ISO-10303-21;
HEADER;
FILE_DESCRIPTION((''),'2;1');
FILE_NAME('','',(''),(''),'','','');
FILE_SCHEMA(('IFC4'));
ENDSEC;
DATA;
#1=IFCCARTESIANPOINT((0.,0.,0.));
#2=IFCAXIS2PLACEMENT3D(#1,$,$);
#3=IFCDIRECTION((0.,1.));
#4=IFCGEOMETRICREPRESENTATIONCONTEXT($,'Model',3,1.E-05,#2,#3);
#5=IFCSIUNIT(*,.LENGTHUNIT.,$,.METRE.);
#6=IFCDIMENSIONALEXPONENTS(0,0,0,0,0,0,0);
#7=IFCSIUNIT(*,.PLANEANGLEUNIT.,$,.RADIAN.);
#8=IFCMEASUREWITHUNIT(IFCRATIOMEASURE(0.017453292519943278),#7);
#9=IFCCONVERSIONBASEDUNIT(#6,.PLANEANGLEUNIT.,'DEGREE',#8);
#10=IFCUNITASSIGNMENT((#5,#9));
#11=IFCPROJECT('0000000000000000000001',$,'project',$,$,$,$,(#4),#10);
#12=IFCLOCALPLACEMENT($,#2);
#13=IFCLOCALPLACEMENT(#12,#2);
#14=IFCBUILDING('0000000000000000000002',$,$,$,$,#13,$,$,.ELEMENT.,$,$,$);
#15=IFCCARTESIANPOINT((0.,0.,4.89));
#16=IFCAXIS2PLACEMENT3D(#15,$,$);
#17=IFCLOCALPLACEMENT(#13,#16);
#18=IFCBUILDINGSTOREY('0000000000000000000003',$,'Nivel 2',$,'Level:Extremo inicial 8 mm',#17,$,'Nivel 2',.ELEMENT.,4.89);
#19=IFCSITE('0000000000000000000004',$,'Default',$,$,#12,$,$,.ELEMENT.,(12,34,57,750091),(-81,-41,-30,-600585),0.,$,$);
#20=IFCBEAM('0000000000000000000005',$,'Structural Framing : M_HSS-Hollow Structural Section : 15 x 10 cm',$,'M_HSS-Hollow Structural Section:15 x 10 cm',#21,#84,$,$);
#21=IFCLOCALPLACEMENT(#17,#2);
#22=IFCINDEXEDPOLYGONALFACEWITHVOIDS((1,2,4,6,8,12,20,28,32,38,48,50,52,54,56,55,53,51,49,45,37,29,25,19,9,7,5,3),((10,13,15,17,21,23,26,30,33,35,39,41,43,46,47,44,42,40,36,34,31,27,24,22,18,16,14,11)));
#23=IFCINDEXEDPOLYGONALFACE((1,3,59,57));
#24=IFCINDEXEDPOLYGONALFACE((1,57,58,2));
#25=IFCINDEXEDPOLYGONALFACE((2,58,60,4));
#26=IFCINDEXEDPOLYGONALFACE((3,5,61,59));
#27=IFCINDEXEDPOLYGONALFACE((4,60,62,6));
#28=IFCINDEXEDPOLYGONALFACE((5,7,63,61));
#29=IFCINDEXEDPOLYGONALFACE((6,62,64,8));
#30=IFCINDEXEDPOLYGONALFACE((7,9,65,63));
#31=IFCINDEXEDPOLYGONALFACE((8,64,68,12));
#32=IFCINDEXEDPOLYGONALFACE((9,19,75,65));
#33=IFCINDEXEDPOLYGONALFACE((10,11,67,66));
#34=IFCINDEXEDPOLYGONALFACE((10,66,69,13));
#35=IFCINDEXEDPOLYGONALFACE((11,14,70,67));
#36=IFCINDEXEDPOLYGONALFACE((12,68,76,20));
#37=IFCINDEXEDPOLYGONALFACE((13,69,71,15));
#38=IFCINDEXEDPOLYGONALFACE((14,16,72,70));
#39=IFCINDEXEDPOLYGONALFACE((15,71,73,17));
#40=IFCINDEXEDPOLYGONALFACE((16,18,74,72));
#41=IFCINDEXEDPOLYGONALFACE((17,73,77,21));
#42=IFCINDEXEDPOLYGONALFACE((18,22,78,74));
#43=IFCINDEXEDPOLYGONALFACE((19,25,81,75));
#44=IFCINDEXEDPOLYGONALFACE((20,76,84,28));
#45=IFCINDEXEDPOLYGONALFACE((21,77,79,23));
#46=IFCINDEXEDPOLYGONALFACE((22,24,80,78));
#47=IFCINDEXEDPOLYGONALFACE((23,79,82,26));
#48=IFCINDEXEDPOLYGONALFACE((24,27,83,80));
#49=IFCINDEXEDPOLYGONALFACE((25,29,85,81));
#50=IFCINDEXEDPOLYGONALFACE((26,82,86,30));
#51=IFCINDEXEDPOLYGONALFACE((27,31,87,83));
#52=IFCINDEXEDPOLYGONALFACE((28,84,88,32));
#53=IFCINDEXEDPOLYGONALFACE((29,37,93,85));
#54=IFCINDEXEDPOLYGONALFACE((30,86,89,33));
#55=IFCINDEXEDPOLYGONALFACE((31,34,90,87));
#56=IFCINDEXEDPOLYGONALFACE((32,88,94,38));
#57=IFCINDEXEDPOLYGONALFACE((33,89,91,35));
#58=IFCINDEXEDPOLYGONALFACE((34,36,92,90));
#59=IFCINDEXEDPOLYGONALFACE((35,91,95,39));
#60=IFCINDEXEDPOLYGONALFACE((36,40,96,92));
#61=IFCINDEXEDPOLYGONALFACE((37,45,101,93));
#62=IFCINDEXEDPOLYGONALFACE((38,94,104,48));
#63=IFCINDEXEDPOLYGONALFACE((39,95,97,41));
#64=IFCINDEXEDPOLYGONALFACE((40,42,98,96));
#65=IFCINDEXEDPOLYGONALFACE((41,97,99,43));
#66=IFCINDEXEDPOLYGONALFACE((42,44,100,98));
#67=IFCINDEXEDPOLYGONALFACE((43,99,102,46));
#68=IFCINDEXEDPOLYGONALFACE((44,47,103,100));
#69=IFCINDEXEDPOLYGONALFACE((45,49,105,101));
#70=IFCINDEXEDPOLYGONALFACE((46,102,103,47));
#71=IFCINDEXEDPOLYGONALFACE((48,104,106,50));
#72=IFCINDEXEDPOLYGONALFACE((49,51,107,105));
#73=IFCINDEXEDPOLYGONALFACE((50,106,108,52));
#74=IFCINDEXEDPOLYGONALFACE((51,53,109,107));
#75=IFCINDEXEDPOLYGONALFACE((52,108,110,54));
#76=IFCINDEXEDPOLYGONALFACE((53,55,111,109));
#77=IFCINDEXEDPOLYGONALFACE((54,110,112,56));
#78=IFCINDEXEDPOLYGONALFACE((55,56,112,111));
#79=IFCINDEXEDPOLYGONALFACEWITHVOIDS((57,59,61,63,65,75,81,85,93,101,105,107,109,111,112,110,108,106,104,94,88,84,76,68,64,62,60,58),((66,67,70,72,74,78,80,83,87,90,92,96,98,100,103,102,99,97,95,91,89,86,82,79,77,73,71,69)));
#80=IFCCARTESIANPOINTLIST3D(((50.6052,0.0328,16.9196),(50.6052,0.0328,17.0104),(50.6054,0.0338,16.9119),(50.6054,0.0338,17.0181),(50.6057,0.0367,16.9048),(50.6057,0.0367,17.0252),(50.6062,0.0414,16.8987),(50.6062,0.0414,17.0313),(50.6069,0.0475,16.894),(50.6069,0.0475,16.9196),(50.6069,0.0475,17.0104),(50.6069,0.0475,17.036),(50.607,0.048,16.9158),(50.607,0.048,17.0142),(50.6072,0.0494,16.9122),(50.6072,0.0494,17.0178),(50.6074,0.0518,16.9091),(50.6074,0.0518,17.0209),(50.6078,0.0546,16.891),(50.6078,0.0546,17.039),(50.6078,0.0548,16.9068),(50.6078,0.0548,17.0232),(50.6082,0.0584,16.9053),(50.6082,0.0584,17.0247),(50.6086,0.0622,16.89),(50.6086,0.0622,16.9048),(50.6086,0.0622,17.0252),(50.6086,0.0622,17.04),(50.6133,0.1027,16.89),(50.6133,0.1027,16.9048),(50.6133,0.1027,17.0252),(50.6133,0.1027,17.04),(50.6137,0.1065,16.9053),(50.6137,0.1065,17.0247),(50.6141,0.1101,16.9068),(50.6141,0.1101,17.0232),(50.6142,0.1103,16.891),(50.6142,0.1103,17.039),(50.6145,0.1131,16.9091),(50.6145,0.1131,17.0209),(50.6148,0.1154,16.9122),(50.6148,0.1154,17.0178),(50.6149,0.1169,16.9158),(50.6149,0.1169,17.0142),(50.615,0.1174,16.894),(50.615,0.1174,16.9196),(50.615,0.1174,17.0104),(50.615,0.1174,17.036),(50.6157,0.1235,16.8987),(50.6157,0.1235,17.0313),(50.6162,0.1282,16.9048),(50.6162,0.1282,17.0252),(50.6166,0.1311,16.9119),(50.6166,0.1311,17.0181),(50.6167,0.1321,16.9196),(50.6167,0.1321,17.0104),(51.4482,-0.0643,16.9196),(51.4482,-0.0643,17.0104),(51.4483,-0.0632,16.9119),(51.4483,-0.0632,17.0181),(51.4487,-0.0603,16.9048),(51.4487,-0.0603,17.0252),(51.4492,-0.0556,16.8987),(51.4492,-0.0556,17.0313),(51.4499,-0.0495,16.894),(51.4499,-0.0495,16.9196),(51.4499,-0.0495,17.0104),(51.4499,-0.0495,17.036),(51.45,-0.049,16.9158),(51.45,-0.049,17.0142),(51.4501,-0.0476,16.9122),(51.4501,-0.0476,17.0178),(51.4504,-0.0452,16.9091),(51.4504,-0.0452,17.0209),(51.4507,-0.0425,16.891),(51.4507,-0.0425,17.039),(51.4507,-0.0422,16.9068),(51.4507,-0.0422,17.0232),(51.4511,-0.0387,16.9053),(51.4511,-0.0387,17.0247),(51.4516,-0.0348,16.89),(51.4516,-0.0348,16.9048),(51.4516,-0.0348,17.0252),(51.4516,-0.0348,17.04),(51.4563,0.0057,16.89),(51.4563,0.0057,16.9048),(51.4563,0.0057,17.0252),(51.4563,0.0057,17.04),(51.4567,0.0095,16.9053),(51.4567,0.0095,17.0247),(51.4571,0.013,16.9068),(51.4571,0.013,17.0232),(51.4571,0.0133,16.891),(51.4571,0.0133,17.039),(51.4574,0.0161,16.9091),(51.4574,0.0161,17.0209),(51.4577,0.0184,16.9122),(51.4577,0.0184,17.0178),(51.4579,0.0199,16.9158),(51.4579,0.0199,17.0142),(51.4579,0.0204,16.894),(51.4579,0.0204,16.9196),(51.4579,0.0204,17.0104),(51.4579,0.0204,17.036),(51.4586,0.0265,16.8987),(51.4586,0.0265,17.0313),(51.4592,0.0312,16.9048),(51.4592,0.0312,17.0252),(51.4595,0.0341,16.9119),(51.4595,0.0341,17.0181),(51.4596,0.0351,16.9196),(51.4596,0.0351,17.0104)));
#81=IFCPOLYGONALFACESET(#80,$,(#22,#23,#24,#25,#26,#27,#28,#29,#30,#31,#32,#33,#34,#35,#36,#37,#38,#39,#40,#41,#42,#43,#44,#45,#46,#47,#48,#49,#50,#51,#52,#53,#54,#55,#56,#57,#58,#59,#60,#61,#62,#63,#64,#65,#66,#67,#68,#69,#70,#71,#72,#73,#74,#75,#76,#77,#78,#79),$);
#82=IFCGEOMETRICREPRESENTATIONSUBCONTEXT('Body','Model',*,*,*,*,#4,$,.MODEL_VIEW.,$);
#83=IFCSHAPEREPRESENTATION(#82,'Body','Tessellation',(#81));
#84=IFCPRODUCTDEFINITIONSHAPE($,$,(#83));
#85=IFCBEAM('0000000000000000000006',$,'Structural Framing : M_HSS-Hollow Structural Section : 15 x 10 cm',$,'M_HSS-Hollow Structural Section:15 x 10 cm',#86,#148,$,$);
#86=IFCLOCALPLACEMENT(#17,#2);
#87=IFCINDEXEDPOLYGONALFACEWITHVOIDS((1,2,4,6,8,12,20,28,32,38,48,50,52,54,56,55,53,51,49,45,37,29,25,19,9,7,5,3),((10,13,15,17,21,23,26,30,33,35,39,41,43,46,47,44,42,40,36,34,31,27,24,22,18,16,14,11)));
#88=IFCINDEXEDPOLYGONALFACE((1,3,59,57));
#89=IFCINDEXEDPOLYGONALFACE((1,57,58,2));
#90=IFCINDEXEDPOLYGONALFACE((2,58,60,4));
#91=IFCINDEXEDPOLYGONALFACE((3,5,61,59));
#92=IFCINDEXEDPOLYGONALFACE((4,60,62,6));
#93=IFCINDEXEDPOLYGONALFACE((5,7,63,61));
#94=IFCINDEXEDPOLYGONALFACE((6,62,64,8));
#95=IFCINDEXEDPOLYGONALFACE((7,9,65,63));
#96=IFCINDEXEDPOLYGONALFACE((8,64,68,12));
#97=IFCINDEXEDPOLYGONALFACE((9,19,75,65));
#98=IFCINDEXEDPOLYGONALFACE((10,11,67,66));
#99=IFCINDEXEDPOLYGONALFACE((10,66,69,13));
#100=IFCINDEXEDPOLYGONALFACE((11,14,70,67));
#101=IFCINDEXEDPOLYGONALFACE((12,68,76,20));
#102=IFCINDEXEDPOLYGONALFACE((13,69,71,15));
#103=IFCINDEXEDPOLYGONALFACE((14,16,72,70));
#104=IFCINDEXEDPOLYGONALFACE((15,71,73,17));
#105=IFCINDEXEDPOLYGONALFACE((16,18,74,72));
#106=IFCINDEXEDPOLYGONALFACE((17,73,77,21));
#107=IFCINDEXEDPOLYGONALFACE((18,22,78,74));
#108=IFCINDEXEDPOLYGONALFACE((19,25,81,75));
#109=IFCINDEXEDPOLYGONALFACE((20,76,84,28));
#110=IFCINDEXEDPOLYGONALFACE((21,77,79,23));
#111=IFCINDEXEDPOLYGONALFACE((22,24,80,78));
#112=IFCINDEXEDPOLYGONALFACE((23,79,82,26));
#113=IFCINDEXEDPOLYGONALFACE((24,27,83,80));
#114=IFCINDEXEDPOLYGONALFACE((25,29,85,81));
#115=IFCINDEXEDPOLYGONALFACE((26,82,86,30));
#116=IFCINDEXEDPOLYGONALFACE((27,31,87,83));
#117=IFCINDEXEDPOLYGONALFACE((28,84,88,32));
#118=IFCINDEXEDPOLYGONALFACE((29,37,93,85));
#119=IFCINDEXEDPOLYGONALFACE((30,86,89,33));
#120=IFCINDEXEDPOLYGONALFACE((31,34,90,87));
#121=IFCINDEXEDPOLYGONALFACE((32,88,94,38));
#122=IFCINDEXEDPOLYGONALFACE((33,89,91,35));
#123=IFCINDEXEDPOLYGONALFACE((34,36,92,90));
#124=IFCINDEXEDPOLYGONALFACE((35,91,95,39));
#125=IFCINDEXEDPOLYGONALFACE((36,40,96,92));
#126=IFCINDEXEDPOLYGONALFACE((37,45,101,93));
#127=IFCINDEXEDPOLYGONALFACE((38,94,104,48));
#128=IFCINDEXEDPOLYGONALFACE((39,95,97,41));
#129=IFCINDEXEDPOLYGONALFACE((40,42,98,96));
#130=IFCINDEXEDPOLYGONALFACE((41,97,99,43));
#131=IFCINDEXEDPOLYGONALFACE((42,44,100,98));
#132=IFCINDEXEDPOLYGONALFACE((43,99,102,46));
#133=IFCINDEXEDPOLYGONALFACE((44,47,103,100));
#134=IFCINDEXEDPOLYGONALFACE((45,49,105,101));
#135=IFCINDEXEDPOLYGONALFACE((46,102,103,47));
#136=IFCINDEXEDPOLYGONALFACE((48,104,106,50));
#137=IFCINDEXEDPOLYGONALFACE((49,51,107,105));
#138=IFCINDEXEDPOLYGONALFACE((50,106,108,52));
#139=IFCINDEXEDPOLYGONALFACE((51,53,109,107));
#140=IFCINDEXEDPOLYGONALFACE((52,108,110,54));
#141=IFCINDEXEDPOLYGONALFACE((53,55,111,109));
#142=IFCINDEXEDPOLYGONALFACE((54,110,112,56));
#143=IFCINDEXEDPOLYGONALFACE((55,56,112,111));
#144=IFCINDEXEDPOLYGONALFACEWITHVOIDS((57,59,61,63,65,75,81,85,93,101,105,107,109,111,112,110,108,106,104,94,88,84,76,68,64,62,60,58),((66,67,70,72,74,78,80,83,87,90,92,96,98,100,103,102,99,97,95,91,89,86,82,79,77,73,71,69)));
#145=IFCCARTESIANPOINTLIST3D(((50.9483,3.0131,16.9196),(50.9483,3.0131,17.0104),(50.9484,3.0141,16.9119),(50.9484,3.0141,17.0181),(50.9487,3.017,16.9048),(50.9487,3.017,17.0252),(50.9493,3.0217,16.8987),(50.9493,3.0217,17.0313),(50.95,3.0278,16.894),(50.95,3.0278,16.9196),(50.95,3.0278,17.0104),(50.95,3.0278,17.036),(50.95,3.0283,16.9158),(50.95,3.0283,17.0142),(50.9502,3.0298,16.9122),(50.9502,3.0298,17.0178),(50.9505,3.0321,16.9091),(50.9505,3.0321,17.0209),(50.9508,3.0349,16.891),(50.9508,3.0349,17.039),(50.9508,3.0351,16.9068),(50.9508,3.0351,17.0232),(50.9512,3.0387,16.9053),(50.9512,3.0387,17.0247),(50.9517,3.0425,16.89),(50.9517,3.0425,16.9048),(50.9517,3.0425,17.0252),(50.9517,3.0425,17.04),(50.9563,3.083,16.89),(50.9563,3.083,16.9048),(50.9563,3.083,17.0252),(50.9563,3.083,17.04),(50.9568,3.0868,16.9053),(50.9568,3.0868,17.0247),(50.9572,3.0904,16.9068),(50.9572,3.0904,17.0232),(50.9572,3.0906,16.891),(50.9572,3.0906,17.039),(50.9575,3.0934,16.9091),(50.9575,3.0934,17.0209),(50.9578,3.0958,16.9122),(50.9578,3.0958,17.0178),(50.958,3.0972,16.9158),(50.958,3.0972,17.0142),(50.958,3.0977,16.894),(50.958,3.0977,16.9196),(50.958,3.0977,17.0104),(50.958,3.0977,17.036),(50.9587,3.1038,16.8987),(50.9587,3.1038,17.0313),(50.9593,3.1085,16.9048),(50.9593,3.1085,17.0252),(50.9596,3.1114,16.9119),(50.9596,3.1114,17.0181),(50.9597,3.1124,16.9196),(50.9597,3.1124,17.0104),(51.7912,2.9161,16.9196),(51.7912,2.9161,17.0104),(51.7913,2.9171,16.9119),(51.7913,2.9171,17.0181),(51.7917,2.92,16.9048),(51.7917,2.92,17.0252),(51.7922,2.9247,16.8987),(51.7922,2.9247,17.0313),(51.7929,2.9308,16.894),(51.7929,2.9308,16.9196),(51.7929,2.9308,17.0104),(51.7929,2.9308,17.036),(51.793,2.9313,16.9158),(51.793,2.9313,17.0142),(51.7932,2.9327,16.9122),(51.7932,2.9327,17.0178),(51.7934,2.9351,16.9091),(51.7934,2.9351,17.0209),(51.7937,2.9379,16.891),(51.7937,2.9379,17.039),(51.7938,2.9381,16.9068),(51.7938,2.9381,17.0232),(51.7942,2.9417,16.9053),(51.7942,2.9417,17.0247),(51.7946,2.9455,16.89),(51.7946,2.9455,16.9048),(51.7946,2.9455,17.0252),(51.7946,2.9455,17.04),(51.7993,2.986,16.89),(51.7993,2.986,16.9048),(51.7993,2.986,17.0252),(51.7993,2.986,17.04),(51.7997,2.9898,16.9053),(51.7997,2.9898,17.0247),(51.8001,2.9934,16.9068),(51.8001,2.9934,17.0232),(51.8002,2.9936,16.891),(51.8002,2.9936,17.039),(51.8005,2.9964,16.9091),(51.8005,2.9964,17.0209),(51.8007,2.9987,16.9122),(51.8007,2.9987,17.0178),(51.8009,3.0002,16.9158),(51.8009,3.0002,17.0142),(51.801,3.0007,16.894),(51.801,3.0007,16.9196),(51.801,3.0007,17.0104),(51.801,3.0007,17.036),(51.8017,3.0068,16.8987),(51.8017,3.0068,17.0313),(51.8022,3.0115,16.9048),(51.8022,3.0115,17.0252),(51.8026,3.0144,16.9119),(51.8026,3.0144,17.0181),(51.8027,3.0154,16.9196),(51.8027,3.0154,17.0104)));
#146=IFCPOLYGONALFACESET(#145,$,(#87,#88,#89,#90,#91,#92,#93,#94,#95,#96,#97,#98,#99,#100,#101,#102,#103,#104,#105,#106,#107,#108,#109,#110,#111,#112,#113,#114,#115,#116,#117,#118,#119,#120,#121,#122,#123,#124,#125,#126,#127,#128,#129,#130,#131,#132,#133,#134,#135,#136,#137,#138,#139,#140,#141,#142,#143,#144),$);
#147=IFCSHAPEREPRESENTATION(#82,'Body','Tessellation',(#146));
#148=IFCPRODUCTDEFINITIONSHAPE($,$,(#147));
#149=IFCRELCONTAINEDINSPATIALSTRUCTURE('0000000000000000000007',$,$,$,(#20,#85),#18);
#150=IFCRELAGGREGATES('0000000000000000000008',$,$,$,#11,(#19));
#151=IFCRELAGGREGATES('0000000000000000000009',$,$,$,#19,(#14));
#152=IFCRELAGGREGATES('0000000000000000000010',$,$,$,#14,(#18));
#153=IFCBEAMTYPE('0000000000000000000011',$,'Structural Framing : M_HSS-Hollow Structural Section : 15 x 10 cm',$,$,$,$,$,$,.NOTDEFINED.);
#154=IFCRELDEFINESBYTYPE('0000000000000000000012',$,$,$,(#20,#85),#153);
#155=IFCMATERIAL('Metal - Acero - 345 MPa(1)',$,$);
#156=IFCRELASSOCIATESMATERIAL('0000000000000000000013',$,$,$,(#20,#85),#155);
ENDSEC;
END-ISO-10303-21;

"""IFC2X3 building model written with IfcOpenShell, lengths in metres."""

from ifc_helpers import new_model, entity, si_unit, converted_unit, direction, frame, frame_2d, origin, place, context, subcontext, project, spatial, polyline, circle_curve, parameter, trimmed, segment, composite_curve, outline, extrude, material, type_object, element, save


model = new_model("IFC2X3")

# Units and contexts
model_context = context("Model", 3, precision=1e-05, world=origin(), true_north=direction((0.0, 1.0)))
body_context = subcontext(model_context, "Body", "Model", "MODEL_VIEW")
ifc_project = project(units=[si_unit("LENGTHUNIT", "METRE"), converted_unit("PLANEANGLEUNIT", "DEGREE", entity("IfcRatioMeasure", 0.017453292519943278), si_unit("PLANEANGLEUNIT", "RADIAN"), dimensions=[0, 0, 0, 0, 0, 0, 0])], contexts=[model_context])

# Site, building, storey
site_placement = place(None, origin())
site = spatial("IfcSite", under=ifc_project, at=site_placement, Name="Default", CompositionType="ELEMENT", RefLatitude=(12, 34, 57, 750091), RefLongitude=(-81, -41, -30, -600585), RefElevation=0.0)
building_placement = place(site_placement, origin())
building = spatial("IfcBuilding", under=site, at=building_placement, CompositionType="ELEMENT")
storey_placement = place(building_placement, frame((0.0, 0.0, 4.89)))
storey = spatial("IfcBuildingStorey", under=building, at=storey_placement, Name="Nivel 2", ObjectType="Level:Extremo inicial 8 mm", LongName="Nivel 2", CompositionType="ELEMENT", Elevation=4.89)

# Shared definitions
ifc_material_1 = material(Name="Metal - Acero - 345 MPa(1)")

# Beams
beam_type_1 = type_object("IfcBeamType", Name="Structural Framing : M_HSS-Hollow Structural Section : 15 x 10 cm", PredefinedType="NOTDEFINED")
beam_1_placement = place(storey_placement, frame((51.8016, -0.0546, 17.04), z_axis=(0.0, 0.0, 1.0), x_axis=(-0.993441, 0.114344, 0.0)))
element("IfcBeam", 1, at=beam_1_placement, inside=storey, type_object=beam_type_1, material=ifc_material_1, Name="Structural Framing : M_HSS-Hollow Structural Section : 15 x 10 cm", ObjectType="M_HSS-Hollow Structural Section:15 x 10 cm", context=body_context, shape_type="SweptSolid", body=[
    extrude(outline(composite_curve([segment(trimmed(circle_curve(frame_2d((-0.0204, -0.0454), x_axis=(1.0, 0.0)), 0.0296), [parameter(180.0)], [parameter(270.0)], True, "PARAMETER"), True, "CONTINUOUS"), segment(polyline([(-0.0204, -0.075), (0.0204, -0.075)]), True, "CONTINUOUS"), segment(trimmed(circle_curve(frame_2d((0.0204, -0.0454), x_axis=(1.0, 0.0)), 0.0296), [parameter(270.0)], [parameter(0.0)], True, "PARAMETER"), True, "CONTINUOUS"), segment(polyline([(0.05, -0.0454), (0.05, 0.0454)]), True, "CONTINUOUS"), segment(trimmed(circle_curve(frame_2d((0.0204, 0.0454), x_axis=(1.0, 0.0)), 0.0296), [parameter(360.0)], [parameter(90.0)], True, "PARAMETER"), True, "CONTINUOUS"), segment(polyline([(0.0204, 0.075), (-0.0204, 0.075)]), True, "CONTINUOUS"), segment(trimmed(circle_curve(frame_2d((-0.0204, 0.0454), x_axis=(1.0, 0.0)), 0.0296), [parameter(90.0)], [parameter(180.0)], True, "PARAMETER"), True, "CONTINUOUS"), segment(polyline([(-0.05, 0.0454), (-0.05, -0.0454)]), True, "CONTINUOUS")], self_intersect=False), holes=[composite_curve([segment(polyline([(0.0204, -0.0602), (-0.0204, -0.0602)]), True, "CONTINUOUS"), segment(trimmed(circle_curve(frame_2d((-0.0204, -0.0454), x_axis=(1.0, 0.0)), 0.0148), [parameter(180.0)], [parameter(270.0)], True, "PARAMETER"), False, "CONTINUOUS"), segment(polyline([(-0.0352, -0.0454), (-0.0352, 0.0454)]), True, "CONTINUOUS"), segment(trimmed(circle_curve(frame_2d((-0.0204, 0.0454), x_axis=(1.0, 0.0)), 0.0148), [parameter(90.0)], [parameter(180.0)], True, "PARAMETER"), False, "CONTINUOUS"), segment(polyline([(-0.0204, 0.0602), (0.0204, 0.0602)]), True, "CONTINUOUS"), segment(trimmed(circle_curve(frame_2d((0.0204, 0.0454), x_axis=(1.0, 0.0)), 0.0148), [parameter(0.0)], [parameter(90.0)], True, "PARAMETER"), False, "CONTINUOUS"), segment(polyline([(0.0352, 0.0454), (0.0352, -0.0454)]), True, "CONTINUOUS"), segment(trimmed(circle_curve(frame_2d((0.0204, -0.0454), x_axis=(1.0, 0.0)), 0.0148), [parameter(270.0)], [parameter(0.0)], True, "PARAMETER"), False, "CONTINUOUS")], self_intersect=False)]), frame((0.35, 0.0, -0.075), z_axis=(1.0, 0.0, 0.0), x_axis=(0.0, -1.0, 0.0)), (0.0, 0.0, 1.0), 0.8485),
])
beam_2_placement = place(storey_placement, frame((52.1447, 2.9257, 17.04), z_axis=(0.0, 0.0, 1.0), x_axis=(-0.993441, 0.114344, 0.0)))
element("IfcBeam", 2, at=beam_2_placement, inside=storey, type_object=beam_type_1, material=ifc_material_1, Name="Structural Framing : M_HSS-Hollow Structural Section : 15 x 10 cm", ObjectType="M_HSS-Hollow Structural Section:15 x 10 cm", context=body_context, shape_type="SweptSolid", body=[
    extrude(outline(composite_curve([segment(trimmed(circle_curve(frame_2d((-0.0204, -0.0454), x_axis=(1.0, 0.0)), 0.0296), [parameter(180.0)], [parameter(270.0)], True, "PARAMETER"), True, "CONTINUOUS"), segment(polyline([(-0.0204, -0.075), (0.0204, -0.075)]), True, "CONTINUOUS"), segment(trimmed(circle_curve(frame_2d((0.0204, -0.0454), x_axis=(1.0, 0.0)), 0.0296), [parameter(270.0)], [parameter(0.0)], True, "PARAMETER"), True, "CONTINUOUS"), segment(polyline([(0.05, -0.0454), (0.05, 0.0454)]), True, "CONTINUOUS"), segment(trimmed(circle_curve(frame_2d((0.0204, 0.0454), x_axis=(1.0, 0.0)), 0.0296), [parameter(360.0)], [parameter(90.0)], True, "PARAMETER"), True, "CONTINUOUS"), segment(polyline([(0.0204, 0.075), (-0.0204, 0.075)]), True, "CONTINUOUS"), segment(trimmed(circle_curve(frame_2d((-0.0204, 0.0454), x_axis=(1.0, 0.0)), 0.0296), [parameter(90.0)], [parameter(180.0)], True, "PARAMETER"), True, "CONTINUOUS"), segment(polyline([(-0.05, 0.0454), (-0.05, -0.0454)]), True, "CONTINUOUS")], self_intersect=False), holes=[composite_curve([segment(polyline([(0.0204, -0.0602), (-0.0204, -0.0602)]), True, "CONTINUOUS"), segment(trimmed(circle_curve(frame_2d((-0.0204, -0.0454), x_axis=(1.0, 0.0)), 0.0148), [parameter(180.0)], [parameter(270.0)], True, "PARAMETER"), False, "CONTINUOUS"), segment(polyline([(-0.0352, -0.0454), (-0.0352, 0.0454)]), True, "CONTINUOUS"), segment(trimmed(circle_curve(frame_2d((-0.0204, 0.0454), x_axis=(1.0, 0.0)), 0.0148), [parameter(90.0)], [parameter(180.0)], True, "PARAMETER"), False, "CONTINUOUS"), segment(polyline([(-0.0204, 0.0602), (0.0204, 0.0602)]), True, "CONTINUOUS"), segment(trimmed(circle_curve(frame_2d((0.0204, 0.0454), x_axis=(1.0, 0.0)), 0.0148), [parameter(0.0)], [parameter(90.0)], True, "PARAMETER"), False, "CONTINUOUS"), segment(polyline([(0.0352, 0.0454), (0.0352, -0.0454)]), True, "CONTINUOUS"), segment(trimmed(circle_curve(frame_2d((0.0204, -0.0454), x_axis=(1.0, 0.0)), 0.0148), [parameter(270.0)], [parameter(0.0)], True, "PARAMETER"), False, "CONTINUOUS")], self_intersect=False)]), frame((0.35, 0.0, -0.075), z_axis=(1.0, 0.0, 0.0), x_axis=(0.0, -1.0, 0.0)), (0.0, 0.0, 1.0), 0.8485),
])

save(model, "model.ifc")
